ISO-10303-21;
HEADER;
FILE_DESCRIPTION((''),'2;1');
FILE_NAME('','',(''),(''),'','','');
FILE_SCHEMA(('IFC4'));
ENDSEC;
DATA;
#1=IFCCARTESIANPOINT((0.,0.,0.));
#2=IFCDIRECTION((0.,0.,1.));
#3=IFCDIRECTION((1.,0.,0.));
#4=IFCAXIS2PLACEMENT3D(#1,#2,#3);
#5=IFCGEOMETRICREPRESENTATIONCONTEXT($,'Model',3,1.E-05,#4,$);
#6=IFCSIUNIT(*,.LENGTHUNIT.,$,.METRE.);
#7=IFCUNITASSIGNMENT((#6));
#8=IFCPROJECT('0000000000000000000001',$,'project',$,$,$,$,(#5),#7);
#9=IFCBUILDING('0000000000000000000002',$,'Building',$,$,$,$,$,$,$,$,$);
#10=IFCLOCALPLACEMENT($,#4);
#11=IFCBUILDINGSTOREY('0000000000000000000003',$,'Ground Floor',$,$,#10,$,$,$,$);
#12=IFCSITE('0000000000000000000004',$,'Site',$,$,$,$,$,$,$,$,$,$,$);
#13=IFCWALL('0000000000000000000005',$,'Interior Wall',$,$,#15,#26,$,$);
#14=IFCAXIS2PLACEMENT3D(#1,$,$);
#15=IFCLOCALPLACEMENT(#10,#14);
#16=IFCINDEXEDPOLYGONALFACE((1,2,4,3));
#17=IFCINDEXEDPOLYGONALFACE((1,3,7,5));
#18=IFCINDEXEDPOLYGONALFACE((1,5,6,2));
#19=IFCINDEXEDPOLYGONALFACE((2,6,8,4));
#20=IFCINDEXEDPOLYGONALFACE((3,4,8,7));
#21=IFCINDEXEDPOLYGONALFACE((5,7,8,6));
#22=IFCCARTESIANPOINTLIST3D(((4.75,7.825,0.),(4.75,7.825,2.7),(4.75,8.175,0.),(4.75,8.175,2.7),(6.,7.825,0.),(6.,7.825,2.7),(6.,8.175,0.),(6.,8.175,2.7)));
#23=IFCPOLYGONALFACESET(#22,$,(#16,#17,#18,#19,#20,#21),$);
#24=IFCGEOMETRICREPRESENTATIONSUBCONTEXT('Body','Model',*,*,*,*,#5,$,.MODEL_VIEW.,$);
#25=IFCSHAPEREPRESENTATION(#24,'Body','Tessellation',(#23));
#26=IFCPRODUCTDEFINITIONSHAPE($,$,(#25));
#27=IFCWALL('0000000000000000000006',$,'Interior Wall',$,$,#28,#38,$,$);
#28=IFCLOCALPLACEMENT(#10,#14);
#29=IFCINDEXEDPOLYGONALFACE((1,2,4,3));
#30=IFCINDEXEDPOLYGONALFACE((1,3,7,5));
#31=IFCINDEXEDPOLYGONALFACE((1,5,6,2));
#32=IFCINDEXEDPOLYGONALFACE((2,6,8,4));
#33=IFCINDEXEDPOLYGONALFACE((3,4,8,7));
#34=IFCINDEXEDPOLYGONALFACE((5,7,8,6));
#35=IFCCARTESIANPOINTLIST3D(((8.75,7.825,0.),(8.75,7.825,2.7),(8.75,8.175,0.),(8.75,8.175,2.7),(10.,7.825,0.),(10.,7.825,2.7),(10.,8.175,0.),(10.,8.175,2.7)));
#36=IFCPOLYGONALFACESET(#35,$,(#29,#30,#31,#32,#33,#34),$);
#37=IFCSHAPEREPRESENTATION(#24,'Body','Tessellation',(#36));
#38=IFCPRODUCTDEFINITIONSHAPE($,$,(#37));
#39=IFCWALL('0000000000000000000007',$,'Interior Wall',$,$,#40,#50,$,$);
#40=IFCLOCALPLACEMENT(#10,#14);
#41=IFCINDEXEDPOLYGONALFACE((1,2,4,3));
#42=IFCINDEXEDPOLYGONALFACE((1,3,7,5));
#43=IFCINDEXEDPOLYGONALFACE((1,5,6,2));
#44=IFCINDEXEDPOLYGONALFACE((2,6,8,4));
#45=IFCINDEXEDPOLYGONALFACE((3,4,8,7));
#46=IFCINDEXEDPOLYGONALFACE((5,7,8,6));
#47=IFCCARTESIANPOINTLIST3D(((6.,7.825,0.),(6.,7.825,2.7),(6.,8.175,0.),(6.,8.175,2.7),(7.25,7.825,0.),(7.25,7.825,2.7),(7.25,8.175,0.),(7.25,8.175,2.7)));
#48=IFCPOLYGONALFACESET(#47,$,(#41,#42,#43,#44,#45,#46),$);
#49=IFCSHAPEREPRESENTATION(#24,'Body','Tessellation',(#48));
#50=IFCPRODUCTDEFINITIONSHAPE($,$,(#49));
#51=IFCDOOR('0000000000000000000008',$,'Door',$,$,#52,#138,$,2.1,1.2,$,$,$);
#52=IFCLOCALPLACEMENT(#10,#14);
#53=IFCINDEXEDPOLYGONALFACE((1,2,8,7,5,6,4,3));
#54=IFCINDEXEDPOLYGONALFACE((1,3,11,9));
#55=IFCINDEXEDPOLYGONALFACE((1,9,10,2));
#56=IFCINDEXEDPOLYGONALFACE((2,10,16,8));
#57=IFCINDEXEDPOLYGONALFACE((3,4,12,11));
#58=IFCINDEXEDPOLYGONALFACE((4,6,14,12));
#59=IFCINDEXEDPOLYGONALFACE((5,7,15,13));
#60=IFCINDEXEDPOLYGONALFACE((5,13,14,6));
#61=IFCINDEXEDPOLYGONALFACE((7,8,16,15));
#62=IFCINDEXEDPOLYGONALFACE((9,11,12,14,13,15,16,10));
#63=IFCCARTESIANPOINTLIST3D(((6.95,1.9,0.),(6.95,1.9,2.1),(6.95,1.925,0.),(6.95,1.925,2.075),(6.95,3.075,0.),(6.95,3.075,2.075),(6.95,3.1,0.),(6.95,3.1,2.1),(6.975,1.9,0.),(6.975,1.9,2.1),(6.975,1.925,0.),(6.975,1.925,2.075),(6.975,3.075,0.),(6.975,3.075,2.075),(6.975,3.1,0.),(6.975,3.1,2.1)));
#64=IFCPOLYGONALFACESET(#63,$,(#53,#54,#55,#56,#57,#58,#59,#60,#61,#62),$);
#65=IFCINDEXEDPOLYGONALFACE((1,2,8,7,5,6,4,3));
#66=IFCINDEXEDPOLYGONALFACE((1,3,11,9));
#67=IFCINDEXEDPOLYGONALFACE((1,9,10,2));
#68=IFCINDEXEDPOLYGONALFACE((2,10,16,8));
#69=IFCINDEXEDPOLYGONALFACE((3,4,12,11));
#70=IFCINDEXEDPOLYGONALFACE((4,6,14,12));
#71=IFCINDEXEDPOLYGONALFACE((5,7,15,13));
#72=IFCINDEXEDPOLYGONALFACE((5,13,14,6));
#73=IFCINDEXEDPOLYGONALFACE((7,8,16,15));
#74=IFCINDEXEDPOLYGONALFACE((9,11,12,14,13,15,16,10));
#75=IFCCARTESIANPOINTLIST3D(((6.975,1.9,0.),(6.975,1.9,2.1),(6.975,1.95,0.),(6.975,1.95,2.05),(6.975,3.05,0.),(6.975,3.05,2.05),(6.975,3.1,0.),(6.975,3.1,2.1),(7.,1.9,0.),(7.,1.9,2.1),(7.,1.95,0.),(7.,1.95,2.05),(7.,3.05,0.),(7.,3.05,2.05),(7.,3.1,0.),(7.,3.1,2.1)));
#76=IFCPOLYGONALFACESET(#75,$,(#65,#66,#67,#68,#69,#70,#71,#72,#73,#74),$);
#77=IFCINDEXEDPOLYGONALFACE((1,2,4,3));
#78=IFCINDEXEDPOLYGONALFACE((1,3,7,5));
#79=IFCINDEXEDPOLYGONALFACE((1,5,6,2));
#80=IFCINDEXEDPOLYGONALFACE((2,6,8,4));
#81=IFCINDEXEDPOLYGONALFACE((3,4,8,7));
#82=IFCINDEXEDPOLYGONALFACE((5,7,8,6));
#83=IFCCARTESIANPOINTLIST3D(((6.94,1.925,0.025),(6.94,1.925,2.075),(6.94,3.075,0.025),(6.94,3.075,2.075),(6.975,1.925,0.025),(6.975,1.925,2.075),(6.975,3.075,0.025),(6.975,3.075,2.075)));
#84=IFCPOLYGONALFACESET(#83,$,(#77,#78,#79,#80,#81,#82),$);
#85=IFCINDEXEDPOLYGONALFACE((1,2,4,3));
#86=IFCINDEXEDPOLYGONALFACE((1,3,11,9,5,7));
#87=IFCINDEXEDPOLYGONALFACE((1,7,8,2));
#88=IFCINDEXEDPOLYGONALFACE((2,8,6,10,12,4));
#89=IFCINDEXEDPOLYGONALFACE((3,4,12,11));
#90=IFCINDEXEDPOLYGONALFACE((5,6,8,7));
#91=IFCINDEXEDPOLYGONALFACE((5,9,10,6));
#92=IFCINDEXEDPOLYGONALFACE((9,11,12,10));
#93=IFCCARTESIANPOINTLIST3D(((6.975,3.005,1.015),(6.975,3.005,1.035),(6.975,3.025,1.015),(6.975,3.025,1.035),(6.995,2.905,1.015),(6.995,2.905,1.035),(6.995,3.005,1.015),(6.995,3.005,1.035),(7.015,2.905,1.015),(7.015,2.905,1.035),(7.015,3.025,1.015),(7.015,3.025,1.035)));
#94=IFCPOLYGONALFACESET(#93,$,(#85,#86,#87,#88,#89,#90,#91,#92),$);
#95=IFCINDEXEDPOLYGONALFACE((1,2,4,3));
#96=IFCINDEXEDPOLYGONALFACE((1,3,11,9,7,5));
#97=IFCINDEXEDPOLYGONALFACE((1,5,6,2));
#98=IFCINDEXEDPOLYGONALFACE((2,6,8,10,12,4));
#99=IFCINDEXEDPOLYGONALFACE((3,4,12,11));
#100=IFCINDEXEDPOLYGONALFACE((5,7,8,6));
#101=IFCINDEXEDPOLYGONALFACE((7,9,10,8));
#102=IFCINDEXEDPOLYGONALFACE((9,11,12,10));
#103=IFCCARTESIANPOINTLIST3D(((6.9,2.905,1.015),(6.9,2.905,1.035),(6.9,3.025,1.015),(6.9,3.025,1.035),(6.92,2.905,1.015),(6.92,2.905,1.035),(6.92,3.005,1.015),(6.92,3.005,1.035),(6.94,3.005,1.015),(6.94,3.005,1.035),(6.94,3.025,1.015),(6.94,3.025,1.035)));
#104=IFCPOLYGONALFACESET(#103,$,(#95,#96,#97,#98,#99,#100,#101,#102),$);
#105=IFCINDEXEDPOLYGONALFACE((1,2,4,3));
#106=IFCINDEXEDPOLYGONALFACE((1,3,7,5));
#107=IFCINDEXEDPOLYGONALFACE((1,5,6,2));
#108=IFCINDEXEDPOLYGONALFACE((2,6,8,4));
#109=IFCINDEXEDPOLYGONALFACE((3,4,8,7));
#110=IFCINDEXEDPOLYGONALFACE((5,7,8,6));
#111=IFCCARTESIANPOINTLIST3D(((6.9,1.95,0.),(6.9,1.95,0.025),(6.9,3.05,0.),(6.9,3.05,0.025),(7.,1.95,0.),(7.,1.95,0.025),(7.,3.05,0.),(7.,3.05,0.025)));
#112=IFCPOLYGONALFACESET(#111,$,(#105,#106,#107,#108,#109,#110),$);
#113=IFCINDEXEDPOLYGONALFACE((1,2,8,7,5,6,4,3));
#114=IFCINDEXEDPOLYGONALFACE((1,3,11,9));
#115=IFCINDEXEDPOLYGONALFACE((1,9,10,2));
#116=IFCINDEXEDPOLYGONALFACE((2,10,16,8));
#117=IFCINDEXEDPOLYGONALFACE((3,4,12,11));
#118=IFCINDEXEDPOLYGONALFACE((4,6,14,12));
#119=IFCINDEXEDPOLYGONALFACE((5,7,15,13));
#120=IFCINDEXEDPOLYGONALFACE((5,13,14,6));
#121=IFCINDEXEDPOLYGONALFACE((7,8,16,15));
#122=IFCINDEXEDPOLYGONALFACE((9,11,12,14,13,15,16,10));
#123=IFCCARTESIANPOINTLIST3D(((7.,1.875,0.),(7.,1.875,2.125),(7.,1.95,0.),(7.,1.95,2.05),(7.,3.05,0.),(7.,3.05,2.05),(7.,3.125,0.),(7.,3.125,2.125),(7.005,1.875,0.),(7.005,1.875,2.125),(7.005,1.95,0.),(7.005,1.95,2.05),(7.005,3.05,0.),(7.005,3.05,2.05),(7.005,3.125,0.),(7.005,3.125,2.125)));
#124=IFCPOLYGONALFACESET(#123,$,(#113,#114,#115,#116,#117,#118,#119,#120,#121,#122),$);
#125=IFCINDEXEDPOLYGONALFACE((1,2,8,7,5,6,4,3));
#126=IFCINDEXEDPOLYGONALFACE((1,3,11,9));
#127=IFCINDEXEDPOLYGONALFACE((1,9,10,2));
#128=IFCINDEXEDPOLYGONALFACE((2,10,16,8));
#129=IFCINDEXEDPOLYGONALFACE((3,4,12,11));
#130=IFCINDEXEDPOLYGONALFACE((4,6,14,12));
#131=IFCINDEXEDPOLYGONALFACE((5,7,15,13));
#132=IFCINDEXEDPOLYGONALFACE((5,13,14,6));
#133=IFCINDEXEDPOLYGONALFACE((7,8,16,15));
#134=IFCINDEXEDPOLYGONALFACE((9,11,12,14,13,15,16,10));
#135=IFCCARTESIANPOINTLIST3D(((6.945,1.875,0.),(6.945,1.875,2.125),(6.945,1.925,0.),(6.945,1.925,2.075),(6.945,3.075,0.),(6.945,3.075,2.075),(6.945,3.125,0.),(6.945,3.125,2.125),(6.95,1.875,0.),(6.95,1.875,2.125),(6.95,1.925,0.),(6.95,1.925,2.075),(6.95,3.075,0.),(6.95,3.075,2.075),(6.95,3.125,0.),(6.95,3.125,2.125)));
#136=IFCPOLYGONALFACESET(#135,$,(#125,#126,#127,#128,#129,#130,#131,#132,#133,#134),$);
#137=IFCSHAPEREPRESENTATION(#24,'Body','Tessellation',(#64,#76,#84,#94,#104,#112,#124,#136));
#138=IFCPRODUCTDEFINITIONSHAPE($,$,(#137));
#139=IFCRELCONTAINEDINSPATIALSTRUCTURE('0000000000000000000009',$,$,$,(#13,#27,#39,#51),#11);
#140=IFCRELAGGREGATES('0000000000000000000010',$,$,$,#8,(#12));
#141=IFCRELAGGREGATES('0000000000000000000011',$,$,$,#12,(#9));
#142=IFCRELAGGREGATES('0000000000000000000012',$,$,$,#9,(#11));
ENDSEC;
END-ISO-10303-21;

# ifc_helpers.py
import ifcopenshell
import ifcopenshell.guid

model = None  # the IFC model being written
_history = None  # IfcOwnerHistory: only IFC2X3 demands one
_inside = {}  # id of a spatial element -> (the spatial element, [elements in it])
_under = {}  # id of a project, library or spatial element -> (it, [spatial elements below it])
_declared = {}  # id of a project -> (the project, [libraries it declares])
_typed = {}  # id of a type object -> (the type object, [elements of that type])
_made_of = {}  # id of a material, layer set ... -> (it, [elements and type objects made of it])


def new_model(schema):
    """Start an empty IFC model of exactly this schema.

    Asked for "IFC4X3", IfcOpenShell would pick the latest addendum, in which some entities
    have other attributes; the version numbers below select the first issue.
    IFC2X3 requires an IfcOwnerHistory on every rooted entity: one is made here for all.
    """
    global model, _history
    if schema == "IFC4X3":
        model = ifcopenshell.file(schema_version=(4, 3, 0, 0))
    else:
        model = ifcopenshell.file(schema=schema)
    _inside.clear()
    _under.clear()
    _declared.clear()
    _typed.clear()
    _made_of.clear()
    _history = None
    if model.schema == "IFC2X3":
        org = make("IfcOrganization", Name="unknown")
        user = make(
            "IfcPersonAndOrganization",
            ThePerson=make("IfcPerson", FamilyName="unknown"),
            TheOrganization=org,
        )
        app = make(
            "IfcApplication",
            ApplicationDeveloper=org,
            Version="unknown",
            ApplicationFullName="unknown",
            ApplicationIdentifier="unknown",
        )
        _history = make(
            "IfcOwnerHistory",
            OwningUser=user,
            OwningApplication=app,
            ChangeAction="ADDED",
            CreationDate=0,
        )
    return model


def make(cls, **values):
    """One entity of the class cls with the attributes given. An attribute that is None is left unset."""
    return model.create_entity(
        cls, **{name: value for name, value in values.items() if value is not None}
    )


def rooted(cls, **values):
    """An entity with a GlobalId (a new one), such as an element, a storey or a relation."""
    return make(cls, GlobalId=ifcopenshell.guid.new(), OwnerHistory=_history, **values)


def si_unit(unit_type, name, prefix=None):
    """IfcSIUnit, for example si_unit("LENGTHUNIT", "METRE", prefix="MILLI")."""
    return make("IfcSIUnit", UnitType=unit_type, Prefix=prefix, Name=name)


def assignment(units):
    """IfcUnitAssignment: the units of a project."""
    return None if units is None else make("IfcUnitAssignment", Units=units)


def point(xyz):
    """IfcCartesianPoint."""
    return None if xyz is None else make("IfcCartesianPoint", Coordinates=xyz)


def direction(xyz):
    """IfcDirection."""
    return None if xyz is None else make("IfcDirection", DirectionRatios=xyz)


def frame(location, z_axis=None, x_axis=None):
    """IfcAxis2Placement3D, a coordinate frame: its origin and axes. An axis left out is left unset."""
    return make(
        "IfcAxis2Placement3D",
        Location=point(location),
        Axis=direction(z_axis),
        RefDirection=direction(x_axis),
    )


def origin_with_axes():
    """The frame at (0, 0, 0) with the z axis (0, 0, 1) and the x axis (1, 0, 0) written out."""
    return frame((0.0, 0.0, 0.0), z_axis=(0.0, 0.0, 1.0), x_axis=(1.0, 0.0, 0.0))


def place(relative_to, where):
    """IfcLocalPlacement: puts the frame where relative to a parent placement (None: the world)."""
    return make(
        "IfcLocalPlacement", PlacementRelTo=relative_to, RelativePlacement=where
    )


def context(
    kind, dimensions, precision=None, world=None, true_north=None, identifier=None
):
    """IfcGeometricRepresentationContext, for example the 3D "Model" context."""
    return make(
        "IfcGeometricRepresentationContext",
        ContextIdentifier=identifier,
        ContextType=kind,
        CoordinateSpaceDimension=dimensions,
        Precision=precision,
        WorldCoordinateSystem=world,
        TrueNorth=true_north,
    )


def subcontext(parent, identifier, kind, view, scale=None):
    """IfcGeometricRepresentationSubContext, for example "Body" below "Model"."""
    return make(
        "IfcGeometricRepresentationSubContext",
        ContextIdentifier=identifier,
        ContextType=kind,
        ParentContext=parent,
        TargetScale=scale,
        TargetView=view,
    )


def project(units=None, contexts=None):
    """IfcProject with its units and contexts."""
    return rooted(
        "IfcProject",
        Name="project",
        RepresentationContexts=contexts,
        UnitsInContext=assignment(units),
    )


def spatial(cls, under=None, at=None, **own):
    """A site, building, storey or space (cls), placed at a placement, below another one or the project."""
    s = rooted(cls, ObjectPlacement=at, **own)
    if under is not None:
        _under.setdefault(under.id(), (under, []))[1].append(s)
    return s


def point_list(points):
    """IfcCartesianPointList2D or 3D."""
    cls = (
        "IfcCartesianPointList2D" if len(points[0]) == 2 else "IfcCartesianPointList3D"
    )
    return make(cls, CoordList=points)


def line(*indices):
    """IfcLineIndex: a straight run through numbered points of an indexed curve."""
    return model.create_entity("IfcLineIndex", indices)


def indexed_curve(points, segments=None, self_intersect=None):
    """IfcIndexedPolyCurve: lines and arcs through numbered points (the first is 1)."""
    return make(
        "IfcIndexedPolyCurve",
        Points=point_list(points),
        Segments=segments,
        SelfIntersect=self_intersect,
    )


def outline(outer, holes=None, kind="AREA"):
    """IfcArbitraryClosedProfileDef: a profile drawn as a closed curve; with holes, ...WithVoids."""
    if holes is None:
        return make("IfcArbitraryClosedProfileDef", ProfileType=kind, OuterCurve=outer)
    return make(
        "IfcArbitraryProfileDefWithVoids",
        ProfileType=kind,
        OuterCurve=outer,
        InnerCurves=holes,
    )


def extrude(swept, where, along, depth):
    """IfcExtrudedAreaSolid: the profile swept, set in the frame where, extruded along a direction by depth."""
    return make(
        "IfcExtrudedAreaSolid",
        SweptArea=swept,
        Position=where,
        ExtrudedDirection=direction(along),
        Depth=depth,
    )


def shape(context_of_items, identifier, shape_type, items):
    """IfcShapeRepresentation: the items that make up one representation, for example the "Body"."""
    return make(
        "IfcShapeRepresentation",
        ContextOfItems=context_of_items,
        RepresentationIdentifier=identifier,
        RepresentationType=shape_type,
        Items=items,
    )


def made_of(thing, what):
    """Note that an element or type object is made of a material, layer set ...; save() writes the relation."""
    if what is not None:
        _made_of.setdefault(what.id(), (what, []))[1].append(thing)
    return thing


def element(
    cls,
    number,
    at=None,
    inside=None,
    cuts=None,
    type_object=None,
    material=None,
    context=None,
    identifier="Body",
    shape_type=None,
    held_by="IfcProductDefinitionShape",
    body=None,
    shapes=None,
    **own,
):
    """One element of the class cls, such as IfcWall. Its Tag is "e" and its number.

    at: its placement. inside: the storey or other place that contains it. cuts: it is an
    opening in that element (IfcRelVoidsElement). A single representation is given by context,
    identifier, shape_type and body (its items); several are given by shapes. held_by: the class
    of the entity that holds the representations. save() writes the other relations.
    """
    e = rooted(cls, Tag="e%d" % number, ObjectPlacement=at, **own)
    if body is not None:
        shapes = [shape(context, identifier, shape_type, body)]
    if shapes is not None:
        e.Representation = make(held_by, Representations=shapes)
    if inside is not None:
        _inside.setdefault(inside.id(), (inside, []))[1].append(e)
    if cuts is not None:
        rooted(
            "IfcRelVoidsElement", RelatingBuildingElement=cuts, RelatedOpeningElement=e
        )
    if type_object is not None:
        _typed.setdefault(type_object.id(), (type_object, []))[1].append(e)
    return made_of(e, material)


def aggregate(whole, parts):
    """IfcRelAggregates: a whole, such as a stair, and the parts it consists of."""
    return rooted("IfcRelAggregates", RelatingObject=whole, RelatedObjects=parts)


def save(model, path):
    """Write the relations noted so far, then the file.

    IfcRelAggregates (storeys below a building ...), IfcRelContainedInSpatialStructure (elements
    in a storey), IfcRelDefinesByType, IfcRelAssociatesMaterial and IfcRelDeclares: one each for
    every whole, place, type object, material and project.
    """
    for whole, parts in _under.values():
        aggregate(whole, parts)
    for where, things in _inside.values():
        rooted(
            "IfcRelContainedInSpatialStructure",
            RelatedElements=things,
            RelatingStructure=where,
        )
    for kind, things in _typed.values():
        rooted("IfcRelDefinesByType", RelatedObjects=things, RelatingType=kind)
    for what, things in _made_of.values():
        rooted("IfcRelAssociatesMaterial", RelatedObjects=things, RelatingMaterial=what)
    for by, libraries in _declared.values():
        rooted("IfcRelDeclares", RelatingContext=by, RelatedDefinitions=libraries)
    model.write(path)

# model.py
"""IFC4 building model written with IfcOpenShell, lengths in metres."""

from ifc_helpers import new_model, si_unit, frame, origin_with_axes, place, context, subcontext, project, spatial, line, indexed_curve, outline, extrude, element, save


model = new_model("IFC4")

# Units and contexts
model_context = context("Model", 3, precision=1e-05, world=origin_with_axes())
body_context = subcontext(model_context, "Body", "Model", "MODEL_VIEW")
ifc_project = project(units=[si_unit("LENGTHUNIT", "METRE")], contexts=[model_context])

# Site, building, storey
site = spatial("IfcSite", under=ifc_project, Name="Site")
building = spatial("IfcBuilding", under=site, Name="Building")
storey_placement = place(None, origin_with_axes())
storey = spatial("IfcBuildingStorey", under=building, at=storey_placement, Name="Ground Floor")

# Walls
for number, where, z_axis, x_axis, name in (
    (1, (6.0, 8.0, 0.0), (0.0, 0.0, 1.0), (-1.0, 0.0, 0.0), "Interior Wall"),
    (2, (10.0, 8.0, 0.0), (0.0, 0.0, 1.0), (-1.0, 0.0, 0.0), "Interior Wall"),
    (3, (7.25, 8.0, 0.0), (0.0, 0.0, 1.0), (-1.0, 0.0, 0.0), "Interior Wall"),
):
    element("IfcWall", number, at=place(storey_placement, frame(where, z_axis=z_axis, x_axis=x_axis)), inside=storey, Name=name, context=body_context, shape_type="SweptSolid", body=[
        extrude(outline(indexed_curve([(0.0, 0.0), (0.0, 0.35), (1.25, 0.35), (1.25, 0.0), (0.0, 0.0)], self_intersect=False)), frame((0.0, -0.175, 0.0), z_axis=(0.0, 0.0, 1.0), x_axis=(1.0, 0.0, 0.0)), (0.0, 0.0, 1.0), 2.7),
    ])

# Door
door_1_placement = place(storey_placement, frame((7.0, 1.9, 0.0), z_axis=(0.0, 0.0, 1.0), x_axis=(0.0, 1.0, 0.0)))
element("IfcDoor", 4, at=door_1_placement, inside=storey, Name="Door", OverallHeight=2.1, OverallWidth=1.2, context=body_context, shape_type="SweptSolid", body=[
    extrude(outline(indexed_curve([(0.0, 0.0), (0.0, 2.1), (1.2, 2.1), (1.2, 0.0), (1.175, 0.0), (1.175, 2.075), (0.025, 2.075), (0.025, 0.0)], segments=[line(1, 2, 3, 4, 5, 6, 7, 8, 1)])), frame((0.0, 0.025, 0.0), z_axis=(0.0, -1.0, 0.0), x_axis=(1.0, 0.0, 0.0)), (0.0, 0.0, -1.0), 0.025),
    extrude(outline(indexed_curve([(0.0, 0.0), (0.0, 2.1), (1.2, 2.1), (1.2, 0.0), (1.15, 0.0), (1.15, 2.05), (0.05, 2.05), (0.05, 0.0)], segments=[line(1, 2, 3, 4, 5, 6, 7, 8, 1)])), frame((0.0, 0.0, 0.0), z_axis=(0.0, -1.0, 0.0), x_axis=(1.0, 0.0, 0.0)), (0.0, 0.0, -1.0), 0.025),
    extrude(outline(indexed_curve([(0.0, 0.0), (1.15, 0.0), (1.15, 0.035), (0.0, 0.035)], segments=[line(1, 2, 3, 4, 1)])), frame((0.025, 0.025, 0.025), z_axis=(0.0, 0.0, 1.0), x_axis=(1.0, 0.0, 0.0)), (0.0, 0.0, 1.0), 2.05),
    extrude(outline(indexed_curve([(0.0, 0.0), (0.0, -0.04), (-0.12, -0.04), (-0.12, -0.02), (-0.02, -0.02), (-0.02, 0.0)], segments=[line(1, 2, 3, 4, 5, 6, 1)])), frame((1.125, 0.025, 1.015), z_axis=(0.0, 0.0, 1.0), x_axis=(1.0, 0.0, 0.0)), (0.0, 0.0, 1.0), 0.02),
    extrude(outline(indexed_curve([(0.0, 0.0), (0.0, 0.04), (-0.12, 0.04), (-0.12, 0.02), (-0.02, 0.02), (-0.02, 0.0)], segments=[line(1, 2, 3, 4, 5, 6, 1)])), frame((1.125, 0.06, 1.015), z_axis=(0.0, 0.0, 1.0), x_axis=(1.0, 0.0, 0.0)), (0.0, 0.0, 1.0), 0.02),
    extrude(outline(indexed_curve([(0.0, 0.0), (1.1, 0.0), (1.1, 0.1), (0.0, 0.1)], segments=[line(1, 2, 3, 4, 1)])), frame((0.05, 0.0, 0.0), z_axis=(0.0, 0.0, 1.0), x_axis=(1.0, 0.0, 0.0)), (0.0, 0.0, 1.0), 0.025),
    extrude(outline(indexed_curve([(0.0, 0.0), (0.0, 2.125), (1.25, 2.125), (1.25, 0.0), (1.175, 0.0), (1.175, 2.05), (0.075, 2.05), (0.075, 0.0)], segments=[line(1, 2, 3, 4, 5, 6, 7, 8, 1)])), frame((-0.025, -0.005, 0.0), z_axis=(0.0, -1.0, 0.0), x_axis=(1.0, 0.0, 0.0)), (0.0, 0.0, -1.0), 0.005),
    extrude(outline(indexed_curve([(0.0, 0.0), (0.0, 2.125), (1.25, 2.125), (1.25, 0.0), (1.2, 0.0), (1.2, 2.075), (0.05, 2.075), (0.05, 0.0)], segments=[line(1, 2, 3, 4, 5, 6, 7, 8, 1)])), frame((-0.025, 0.05, 0.0), z_axis=(0.0, -1.0, 0.0), x_axis=(1.0, 0.0, 0.0)), (0.0, 0.0, -1.0), 0.005),
])

save(model, "model.ifc")
